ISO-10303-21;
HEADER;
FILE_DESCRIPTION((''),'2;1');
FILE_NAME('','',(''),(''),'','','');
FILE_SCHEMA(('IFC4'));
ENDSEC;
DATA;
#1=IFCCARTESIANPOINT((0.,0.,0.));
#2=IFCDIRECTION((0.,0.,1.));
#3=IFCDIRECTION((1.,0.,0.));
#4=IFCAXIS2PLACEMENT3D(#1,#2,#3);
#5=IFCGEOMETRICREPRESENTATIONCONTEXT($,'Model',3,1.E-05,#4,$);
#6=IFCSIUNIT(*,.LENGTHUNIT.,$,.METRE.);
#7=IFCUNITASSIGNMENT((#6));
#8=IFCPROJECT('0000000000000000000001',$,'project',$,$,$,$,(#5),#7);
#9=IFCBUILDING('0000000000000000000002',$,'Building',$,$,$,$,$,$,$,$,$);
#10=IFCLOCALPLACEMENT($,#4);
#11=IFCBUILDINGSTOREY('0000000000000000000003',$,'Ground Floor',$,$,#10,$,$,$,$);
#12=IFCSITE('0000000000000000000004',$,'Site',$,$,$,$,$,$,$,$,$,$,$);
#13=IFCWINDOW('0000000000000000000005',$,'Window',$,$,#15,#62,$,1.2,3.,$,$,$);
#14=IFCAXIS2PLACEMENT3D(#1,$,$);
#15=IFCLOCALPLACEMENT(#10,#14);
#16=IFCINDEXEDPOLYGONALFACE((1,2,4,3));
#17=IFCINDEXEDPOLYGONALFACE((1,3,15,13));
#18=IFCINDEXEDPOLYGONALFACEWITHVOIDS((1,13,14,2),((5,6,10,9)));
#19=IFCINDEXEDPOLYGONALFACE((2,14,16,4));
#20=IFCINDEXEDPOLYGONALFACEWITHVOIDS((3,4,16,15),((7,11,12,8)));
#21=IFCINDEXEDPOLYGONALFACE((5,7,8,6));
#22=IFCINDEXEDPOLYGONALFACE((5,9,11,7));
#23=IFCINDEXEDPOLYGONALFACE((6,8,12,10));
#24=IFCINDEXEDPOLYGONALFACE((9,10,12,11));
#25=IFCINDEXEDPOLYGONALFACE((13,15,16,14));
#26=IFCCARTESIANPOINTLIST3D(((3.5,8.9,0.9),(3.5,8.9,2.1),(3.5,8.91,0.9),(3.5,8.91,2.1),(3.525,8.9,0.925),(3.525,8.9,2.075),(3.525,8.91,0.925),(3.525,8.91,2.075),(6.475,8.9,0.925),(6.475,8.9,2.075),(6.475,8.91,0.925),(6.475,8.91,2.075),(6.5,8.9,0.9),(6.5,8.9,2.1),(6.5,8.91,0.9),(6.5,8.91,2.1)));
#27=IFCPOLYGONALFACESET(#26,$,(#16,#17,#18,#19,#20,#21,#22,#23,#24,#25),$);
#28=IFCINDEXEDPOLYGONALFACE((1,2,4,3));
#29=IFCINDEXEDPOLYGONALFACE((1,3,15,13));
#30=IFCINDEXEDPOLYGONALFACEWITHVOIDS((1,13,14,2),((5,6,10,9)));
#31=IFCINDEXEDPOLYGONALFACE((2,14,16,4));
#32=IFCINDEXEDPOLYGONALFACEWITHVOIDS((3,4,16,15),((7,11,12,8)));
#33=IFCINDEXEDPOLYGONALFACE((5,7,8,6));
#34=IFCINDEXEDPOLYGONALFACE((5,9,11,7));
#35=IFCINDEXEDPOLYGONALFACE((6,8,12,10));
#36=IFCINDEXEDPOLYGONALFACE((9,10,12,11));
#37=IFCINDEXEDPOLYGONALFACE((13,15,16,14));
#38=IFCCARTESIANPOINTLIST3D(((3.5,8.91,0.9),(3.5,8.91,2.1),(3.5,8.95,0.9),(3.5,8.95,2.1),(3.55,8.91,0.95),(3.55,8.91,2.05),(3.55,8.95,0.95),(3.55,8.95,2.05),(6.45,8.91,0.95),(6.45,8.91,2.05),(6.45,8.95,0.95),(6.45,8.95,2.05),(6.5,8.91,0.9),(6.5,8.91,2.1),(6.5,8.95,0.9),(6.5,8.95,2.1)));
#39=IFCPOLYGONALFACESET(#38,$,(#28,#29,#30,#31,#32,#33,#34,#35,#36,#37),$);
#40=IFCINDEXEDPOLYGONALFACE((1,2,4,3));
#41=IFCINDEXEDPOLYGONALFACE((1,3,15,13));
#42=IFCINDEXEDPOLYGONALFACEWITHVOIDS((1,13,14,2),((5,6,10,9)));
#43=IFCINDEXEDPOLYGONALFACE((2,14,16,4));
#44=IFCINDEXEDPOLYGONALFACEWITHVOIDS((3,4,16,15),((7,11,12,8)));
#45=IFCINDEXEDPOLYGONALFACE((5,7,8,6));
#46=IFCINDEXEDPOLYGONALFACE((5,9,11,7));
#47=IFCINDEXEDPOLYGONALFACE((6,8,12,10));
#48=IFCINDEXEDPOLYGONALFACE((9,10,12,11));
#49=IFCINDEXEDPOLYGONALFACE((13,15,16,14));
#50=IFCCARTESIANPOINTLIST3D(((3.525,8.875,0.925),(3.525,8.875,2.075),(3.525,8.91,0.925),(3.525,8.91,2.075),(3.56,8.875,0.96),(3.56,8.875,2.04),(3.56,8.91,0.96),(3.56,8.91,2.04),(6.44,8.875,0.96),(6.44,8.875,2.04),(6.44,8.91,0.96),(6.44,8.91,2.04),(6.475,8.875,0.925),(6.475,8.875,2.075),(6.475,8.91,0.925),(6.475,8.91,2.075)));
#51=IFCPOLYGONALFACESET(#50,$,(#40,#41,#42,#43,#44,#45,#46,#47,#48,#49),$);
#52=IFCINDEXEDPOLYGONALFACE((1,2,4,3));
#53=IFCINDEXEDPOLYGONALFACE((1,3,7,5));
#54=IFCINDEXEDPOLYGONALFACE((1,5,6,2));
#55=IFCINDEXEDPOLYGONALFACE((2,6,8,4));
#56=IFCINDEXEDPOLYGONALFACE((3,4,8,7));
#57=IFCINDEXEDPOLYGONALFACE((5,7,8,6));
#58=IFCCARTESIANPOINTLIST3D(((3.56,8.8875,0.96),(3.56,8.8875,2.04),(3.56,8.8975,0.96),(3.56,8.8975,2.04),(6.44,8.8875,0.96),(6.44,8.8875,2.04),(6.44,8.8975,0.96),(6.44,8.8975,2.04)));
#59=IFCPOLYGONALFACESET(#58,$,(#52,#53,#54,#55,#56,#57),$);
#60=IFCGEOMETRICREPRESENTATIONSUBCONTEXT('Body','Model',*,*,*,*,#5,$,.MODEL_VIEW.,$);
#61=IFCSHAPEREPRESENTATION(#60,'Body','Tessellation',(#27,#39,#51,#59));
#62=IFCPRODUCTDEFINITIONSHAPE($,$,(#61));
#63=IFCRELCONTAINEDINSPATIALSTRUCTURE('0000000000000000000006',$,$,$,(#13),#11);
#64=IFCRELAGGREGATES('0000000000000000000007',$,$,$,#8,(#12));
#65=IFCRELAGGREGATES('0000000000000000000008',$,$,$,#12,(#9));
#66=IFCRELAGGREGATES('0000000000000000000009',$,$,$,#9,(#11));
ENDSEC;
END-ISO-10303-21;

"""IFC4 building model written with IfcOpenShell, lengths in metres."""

from ifc_helpers import new_model, si_unit, frame, origin_with_axes, place, context, subcontext, project, spatial, line, indexed_curve, outline, extrude, element, save


model = new_model("IFC4")

# Units and contexts
model_context = context("Model", 3, precision=1e-05, world=origin_with_axes())
body_context = subcontext(model_context, "Body", "Model", "MODEL_VIEW")
ifc_project = project(units=[si_unit("LENGTHUNIT", "METRE")], contexts=[model_context])

# Site, building, storey
site = spatial("IfcSite", under=ifc_project, Name="Site")
building = spatial("IfcBuilding", under=site, Name="Building")
storey_placement = place(None, origin_with_axes())
storey = spatial("IfcBuildingStorey", under=building, at=storey_placement, Name="Ground Floor")

# Window
window_1_placement = place(storey_placement, frame((6.5, 9.0, 0.9), z_axis=(0.0, 0.0, 1.0), x_axis=(-1.0, 0.0, 0.0)))
element("IfcWindow", 1, at=window_1_placement, inside=storey, Name="Window", OverallHeight=1.2, OverallWidth=3.0, context=body_context, shape_type="SweptSolid", body=[
    extrude(outline(indexed_curve([(0.0, 0.0), (3.0, 0.0), (3.0, 1.2), (0.0, 1.2)], segments=[line(1, 2, 3, 4, 1)]), holes=[indexed_curve([(0.025, 0.025), (2.975, 0.025), (2.975, 1.175), (0.025, 1.175)], segments=[line(1, 2, 3, 4, 1)])]), frame((0.0, 0.09, 0.0), z_axis=(0.0, -1.0, 0.0), x_axis=(1.0, 0.0, 0.0)), (0.0, 0.0, -1.0), 0.01),
    extrude(outline(indexed_curve([(0.0, 0.0), (3.0, 0.0), (3.0, 1.2), (0.0, 1.2)], segments=[line(1, 2, 3, 4, 1)]), holes=[indexed_curve([(0.05, 0.05), (2.95, 0.05), (2.95, 1.15), (0.05, 1.15)], segments=[line(1, 2, 3, 4, 1)])]), frame((0.0, 0.05, 0.0), z_axis=(0.0, -1.0, 0.0), x_axis=(1.0, 0.0, 0.0)), (0.0, 0.0, -1.0), 0.04),
    extrude(outline(indexed_curve([(0.0, 0.0), (2.95, 0.0), (2.95, 1.15), (0.0, 1.15)], segments=[line(1, 2, 3, 4, 1)]), holes=[indexed_curve([(0.035, 0.035), (2.915, 0.035), (2.915, 1.115), (0.035, 1.115)], segments=[line(1, 2, 3, 4, 1)])]), frame((0.025, 0.09, 0.025), z_axis=(0.0, -1.0, 0.0), x_axis=(1.0, 0.0, 0.0)), (0.0, 0.0, -1.0), 0.035),
    extrude(outline(indexed_curve([(0.035, 0.035), (2.915, 0.035), (2.915, 1.115), (0.035, 1.115)], segments=[line(1, 2, 3, 4, 1)])), frame((0.025, 0.1025, 0.025), z_axis=(0.0, -1.0, 0.0), x_axis=(1.0, 0.0, 0.0)), (0.0, 0.0, -1.0), 0.01),
])

save(model, "model.ifc")
